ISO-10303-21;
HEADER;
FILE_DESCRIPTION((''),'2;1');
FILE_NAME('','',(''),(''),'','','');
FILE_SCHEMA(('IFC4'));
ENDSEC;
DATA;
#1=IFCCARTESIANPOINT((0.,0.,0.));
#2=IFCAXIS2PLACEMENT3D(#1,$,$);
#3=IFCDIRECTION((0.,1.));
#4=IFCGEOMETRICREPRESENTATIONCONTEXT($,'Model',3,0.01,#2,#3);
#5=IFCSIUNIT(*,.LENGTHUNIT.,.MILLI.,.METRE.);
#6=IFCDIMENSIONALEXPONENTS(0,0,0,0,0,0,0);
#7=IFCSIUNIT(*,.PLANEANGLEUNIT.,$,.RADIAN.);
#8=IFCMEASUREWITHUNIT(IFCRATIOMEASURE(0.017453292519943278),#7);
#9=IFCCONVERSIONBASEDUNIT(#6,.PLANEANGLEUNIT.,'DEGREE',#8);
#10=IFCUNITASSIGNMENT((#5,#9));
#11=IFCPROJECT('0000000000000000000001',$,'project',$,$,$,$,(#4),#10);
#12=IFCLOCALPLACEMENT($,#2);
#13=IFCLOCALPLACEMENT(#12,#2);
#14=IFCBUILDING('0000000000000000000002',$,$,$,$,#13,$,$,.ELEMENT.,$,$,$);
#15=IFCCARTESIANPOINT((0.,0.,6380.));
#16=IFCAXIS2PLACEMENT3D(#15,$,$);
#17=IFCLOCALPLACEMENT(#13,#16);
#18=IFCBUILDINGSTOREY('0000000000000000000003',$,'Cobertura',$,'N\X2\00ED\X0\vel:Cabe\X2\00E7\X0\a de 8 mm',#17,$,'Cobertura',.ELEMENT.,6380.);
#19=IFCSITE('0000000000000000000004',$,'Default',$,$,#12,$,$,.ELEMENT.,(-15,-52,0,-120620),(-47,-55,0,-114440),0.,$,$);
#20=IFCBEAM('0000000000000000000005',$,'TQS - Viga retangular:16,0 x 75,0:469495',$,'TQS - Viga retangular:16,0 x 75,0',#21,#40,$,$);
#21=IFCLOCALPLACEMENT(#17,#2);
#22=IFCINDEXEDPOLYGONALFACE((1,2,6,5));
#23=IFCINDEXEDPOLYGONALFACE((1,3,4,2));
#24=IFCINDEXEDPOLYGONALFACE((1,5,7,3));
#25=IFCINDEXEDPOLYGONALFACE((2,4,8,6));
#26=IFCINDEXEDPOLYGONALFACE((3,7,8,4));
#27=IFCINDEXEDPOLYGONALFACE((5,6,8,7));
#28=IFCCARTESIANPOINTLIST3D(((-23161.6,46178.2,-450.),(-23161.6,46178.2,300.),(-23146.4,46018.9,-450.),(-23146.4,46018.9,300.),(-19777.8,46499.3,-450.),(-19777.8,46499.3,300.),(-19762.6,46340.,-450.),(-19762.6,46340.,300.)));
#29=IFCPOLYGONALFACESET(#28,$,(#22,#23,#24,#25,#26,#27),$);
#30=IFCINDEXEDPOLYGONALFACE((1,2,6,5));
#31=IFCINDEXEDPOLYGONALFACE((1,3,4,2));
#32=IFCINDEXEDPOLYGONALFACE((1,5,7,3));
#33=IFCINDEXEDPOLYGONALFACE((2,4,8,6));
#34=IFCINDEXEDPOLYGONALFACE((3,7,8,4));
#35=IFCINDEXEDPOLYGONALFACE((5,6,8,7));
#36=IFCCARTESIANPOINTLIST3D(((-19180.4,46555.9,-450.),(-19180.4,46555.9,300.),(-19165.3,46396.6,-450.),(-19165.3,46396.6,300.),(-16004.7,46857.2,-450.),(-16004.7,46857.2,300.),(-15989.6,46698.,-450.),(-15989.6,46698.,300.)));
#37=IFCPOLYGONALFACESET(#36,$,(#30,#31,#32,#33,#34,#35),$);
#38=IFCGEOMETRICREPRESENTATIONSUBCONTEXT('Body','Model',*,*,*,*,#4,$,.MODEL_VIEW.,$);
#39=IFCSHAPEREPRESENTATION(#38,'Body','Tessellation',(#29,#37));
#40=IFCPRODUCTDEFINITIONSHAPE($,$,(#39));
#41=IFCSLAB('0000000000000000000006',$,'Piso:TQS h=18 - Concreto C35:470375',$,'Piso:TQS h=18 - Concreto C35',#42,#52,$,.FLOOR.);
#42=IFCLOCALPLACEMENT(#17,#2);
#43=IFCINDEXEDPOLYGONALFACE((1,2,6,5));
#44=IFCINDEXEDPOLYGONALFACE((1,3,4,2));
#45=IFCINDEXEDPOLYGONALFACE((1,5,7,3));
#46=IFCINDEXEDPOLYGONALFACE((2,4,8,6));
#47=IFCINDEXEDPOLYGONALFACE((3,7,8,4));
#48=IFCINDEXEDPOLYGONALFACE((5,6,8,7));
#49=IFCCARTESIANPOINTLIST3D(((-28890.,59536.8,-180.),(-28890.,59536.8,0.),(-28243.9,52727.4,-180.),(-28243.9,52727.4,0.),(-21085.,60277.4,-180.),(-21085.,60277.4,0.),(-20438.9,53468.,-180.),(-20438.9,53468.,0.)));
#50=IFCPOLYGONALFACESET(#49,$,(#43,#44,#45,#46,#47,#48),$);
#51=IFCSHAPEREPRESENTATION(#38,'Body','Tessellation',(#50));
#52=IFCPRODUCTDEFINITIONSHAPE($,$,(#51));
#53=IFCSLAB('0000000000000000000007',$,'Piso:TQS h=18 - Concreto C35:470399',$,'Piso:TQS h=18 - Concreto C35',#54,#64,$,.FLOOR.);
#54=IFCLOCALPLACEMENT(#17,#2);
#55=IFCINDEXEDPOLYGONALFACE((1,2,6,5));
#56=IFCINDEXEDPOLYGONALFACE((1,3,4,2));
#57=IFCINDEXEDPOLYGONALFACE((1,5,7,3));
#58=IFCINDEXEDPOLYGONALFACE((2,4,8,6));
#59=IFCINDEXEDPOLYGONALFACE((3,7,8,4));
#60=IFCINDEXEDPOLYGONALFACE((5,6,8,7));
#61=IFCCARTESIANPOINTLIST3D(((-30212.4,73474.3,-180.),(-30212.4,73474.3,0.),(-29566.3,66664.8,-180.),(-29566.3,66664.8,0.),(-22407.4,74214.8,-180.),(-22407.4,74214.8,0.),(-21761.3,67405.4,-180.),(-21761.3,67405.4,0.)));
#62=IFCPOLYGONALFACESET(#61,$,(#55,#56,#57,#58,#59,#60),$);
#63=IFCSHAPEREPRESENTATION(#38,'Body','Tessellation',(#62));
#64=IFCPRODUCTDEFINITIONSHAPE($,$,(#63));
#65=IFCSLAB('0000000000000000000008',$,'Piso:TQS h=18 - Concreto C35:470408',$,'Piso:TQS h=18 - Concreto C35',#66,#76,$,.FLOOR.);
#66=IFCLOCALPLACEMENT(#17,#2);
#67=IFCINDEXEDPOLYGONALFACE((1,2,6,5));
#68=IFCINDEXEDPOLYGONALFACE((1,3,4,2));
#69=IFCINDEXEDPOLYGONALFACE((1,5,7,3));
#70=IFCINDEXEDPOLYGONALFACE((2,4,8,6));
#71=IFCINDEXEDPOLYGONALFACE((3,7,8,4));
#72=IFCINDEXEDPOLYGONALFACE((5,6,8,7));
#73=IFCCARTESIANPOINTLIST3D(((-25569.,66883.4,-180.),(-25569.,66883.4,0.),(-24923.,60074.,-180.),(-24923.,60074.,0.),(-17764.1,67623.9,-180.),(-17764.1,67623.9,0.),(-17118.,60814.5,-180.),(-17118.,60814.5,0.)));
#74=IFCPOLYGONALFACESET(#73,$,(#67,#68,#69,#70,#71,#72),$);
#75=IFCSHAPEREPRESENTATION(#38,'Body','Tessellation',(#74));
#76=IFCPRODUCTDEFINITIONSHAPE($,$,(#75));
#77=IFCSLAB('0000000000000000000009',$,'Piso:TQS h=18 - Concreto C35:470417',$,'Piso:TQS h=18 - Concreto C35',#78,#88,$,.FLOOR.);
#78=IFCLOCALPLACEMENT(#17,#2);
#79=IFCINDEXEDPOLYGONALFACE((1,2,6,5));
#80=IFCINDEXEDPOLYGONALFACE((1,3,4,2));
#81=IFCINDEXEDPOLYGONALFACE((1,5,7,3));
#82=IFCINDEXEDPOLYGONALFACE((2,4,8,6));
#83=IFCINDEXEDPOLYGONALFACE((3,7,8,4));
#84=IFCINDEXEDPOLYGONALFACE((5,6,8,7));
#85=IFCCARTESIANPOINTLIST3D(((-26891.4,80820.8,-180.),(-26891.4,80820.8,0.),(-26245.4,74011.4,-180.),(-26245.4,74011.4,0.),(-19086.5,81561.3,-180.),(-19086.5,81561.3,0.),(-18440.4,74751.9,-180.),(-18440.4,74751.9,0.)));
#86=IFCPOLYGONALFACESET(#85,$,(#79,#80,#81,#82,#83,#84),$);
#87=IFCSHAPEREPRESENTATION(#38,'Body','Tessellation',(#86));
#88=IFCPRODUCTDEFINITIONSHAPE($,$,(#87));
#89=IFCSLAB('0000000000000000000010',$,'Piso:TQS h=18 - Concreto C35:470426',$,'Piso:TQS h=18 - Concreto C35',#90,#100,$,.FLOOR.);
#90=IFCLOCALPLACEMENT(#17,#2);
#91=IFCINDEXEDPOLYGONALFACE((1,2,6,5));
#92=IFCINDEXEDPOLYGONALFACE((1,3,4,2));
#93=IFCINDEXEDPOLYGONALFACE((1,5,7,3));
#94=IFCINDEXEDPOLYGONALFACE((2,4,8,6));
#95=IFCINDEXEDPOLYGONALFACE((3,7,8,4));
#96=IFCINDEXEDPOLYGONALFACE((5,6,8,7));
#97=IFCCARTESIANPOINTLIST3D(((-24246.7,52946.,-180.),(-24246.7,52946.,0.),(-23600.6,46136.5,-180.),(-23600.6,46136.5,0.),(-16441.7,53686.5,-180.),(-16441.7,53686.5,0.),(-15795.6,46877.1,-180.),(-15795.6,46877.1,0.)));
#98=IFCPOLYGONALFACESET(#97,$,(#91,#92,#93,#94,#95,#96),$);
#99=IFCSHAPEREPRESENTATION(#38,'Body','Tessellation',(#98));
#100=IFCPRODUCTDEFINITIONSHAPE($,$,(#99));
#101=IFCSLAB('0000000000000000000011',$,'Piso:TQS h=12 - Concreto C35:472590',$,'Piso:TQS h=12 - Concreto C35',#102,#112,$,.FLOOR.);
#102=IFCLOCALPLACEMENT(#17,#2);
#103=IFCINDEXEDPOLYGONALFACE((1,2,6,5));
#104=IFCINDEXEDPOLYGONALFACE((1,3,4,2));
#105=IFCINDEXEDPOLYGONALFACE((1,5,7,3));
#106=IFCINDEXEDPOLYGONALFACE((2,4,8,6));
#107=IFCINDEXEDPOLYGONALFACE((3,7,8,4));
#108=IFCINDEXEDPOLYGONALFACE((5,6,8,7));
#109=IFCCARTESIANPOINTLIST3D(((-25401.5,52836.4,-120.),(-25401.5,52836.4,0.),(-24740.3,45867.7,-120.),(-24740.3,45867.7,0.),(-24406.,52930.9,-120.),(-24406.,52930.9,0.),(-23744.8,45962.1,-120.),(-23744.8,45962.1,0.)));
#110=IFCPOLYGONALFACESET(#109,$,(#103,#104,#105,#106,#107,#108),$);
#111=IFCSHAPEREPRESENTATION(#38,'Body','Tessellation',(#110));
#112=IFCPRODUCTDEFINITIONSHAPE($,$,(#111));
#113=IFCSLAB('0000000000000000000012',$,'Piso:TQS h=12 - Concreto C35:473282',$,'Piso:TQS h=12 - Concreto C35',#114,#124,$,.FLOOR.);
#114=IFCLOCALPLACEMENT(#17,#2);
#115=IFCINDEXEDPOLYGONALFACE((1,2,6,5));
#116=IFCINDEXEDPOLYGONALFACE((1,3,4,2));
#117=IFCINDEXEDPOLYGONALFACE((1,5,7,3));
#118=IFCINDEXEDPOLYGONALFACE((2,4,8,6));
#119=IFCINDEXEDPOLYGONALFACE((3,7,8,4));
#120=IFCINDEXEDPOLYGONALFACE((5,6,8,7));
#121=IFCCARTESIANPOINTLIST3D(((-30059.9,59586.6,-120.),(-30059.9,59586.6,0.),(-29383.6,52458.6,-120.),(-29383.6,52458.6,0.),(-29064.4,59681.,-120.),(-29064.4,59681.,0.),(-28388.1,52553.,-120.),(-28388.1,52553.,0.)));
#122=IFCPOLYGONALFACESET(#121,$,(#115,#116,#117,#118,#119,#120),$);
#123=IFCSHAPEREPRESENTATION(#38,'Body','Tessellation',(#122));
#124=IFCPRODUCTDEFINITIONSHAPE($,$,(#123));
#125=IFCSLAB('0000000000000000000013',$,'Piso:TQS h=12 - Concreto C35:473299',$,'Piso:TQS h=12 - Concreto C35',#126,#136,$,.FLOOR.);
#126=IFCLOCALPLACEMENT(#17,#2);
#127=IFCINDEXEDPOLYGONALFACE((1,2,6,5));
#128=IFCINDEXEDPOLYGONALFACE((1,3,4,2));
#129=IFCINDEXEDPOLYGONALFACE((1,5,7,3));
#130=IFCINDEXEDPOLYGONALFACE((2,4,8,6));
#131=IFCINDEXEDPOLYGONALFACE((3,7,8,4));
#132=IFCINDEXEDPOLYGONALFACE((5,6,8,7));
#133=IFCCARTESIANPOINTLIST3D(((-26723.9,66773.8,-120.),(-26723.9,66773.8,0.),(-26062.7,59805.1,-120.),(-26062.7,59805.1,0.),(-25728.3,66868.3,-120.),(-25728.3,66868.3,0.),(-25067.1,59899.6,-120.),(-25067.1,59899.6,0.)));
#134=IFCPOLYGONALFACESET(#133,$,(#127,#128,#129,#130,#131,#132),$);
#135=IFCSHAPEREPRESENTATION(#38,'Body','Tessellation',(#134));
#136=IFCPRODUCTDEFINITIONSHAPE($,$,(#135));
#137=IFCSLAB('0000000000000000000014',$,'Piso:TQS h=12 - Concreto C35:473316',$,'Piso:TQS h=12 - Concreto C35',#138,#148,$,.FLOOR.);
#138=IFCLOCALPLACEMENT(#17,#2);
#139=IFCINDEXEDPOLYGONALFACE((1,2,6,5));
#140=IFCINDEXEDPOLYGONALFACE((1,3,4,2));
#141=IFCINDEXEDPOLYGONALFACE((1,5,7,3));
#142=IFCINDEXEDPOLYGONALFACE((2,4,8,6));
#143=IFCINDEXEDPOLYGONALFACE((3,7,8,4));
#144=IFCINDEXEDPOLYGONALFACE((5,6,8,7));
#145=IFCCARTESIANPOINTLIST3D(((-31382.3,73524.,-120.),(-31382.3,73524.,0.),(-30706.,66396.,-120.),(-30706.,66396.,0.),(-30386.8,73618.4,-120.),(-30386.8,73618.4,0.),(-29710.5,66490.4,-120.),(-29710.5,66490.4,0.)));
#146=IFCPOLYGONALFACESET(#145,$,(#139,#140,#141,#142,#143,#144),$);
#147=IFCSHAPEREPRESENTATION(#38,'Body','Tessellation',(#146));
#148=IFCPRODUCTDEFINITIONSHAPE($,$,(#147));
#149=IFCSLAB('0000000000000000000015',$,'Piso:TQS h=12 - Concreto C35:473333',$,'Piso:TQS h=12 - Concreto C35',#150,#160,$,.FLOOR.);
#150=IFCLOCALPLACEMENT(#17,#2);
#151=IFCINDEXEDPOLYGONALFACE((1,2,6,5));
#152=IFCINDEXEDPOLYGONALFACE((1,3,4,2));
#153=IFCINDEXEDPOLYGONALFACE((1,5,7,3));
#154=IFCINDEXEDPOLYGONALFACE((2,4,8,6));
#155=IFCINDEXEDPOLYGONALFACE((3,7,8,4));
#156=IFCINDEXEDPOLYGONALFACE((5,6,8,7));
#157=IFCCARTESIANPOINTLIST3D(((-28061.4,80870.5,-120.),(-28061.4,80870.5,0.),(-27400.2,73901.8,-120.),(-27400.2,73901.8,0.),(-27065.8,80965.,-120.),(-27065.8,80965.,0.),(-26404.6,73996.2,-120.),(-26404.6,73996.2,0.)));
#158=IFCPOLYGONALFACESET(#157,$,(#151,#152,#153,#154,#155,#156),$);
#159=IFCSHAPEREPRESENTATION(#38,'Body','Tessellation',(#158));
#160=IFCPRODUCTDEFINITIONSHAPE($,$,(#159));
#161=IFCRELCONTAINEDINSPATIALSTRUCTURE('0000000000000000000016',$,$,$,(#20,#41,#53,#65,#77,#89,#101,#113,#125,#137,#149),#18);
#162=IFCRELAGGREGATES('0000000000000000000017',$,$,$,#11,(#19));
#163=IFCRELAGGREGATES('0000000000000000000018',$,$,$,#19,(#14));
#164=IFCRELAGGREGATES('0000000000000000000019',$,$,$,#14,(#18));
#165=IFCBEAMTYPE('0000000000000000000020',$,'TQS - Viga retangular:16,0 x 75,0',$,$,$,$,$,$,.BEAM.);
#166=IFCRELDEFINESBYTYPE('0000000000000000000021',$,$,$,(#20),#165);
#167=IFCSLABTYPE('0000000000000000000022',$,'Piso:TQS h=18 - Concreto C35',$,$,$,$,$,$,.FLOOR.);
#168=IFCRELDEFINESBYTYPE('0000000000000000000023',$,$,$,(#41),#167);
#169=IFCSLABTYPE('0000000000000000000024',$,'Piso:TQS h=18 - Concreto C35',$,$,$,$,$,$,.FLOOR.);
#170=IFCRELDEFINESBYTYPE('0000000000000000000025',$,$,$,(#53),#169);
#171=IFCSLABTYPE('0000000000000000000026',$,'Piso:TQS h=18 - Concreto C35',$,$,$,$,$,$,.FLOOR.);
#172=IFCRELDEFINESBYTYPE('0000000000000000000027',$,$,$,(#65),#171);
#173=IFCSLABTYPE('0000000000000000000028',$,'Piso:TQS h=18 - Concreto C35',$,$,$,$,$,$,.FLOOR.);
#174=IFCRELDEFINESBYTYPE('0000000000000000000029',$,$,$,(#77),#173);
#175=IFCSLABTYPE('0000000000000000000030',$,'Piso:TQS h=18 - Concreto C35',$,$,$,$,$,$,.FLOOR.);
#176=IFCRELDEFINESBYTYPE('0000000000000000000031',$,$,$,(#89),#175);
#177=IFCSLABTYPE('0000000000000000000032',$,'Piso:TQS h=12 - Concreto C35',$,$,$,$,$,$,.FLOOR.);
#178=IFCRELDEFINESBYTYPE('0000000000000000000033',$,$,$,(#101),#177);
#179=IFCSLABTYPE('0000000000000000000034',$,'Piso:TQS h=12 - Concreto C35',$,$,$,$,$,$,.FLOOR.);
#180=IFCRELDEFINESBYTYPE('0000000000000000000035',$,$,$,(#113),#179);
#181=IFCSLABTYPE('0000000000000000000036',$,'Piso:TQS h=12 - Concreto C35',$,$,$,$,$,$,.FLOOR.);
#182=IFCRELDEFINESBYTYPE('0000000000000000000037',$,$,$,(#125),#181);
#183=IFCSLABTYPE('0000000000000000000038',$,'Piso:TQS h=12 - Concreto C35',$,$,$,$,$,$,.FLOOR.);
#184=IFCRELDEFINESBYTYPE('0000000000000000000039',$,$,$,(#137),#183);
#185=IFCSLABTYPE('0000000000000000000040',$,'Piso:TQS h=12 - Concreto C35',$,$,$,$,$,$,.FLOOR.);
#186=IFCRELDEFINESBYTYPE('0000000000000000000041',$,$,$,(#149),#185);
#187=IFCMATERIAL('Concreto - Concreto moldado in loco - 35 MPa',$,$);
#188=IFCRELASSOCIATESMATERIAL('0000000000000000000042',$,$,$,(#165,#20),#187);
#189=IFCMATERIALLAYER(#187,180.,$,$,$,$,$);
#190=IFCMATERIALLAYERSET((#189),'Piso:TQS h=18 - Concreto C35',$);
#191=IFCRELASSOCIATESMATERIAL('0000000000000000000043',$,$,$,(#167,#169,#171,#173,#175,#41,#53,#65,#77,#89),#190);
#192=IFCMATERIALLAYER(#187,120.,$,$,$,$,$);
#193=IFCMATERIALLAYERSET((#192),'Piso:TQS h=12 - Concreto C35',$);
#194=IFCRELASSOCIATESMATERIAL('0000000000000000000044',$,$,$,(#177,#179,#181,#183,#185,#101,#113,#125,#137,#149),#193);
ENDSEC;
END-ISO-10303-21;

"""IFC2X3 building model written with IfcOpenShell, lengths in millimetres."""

from ifc_helpers import new_model, entity, si_unit, converted_unit, direction, frame, frame_2d, origin, place, context, subcontext, project, spatial, rectangle, extrude, source, transform, mapped, material, layer, layer_set, layer_usage, type_object, type_shapes, element, save


model = new_model("IFC2X3")

# Units and contexts
model_context = context("Model", 3, precision=0.01, world=origin(), true_north=direction((0.0, 1.0)))
body_context = subcontext(model_context, "Body", "Model", "MODEL_VIEW")
ifc_project = project(units=[si_unit("LENGTHUNIT", "METRE", prefix="MILLI"), converted_unit("PLANEANGLEUNIT", "DEGREE", entity("IfcRatioMeasure", 0.017453292519943278), si_unit("PLANEANGLEUNIT", "RADIAN"), dimensions=[0, 0, 0, 0, 0, 0, 0])], contexts=[model_context])

# Site, building, storey
site_placement = place(None, origin())
site = spatial("IfcSite", under=ifc_project, at=site_placement, Name="Default", CompositionType="ELEMENT", RefLatitude=(-15, -52, 0, -120620), RefLongitude=(-47, -55, 0, -114440), RefElevation=0.0)
building_placement = place(site_placement, origin())
building = spatial("IfcBuilding", under=site, at=building_placement, CompositionType="ELEMENT")
storey_placement = place(building_placement, frame((0.0, 0.0, 6380.0)))
storey = spatial("IfcBuildingStorey", under=building, at=storey_placement, Name="Cobertura", ObjectType="Nível:Cabeça de 8 mm", LongName="Cobertura", CompositionType="ELEMENT", Elevation=6380.0)

# Beam
ifc_material = material(Name="Concreto - Concreto moldado in loco - 35 MPa")
beam_type_1 = type_object("IfcBeamType", Name="TQS - Viga retangular:16,0 x 75,0", PredefinedType="BEAM", material=ifc_material)
shared_shape_1 = source(origin(), body_context, "Body", "SweptSolid", [
    extrude(rectangle(XDim=750.0, YDim=160.0, at=frame_2d((0.0, 0.0), x_axis=(1.0, 0.0))), frame((-19770.2, 46419.6, 6305.0), z_axis=(-0.995529, -0.094456, 0.0), x_axis=(0.0, 0.0, -1.0)), (0.0, 0.0, 1.0), 3399.0),
    extrude(rectangle(XDim=750.0, YDim=160.0, at=frame_2d((0.0, 0.0), x_axis=(1.0, 0.0))), frame((-15997.1, 46777.6, 6305.0), z_axis=(-0.995529, -0.094456, 0.0), x_axis=(0.0, 0.0, -1.0)), (0.0, 0.0, 1.0), 3190.0),
])
type_shapes(beam_type_1, [shared_shape_1])
beam_1_placement = place(storey_placement, frame((0.0, 0.0, -6380.0)))
element("IfcBeam", 1, at=beam_1_placement, inside=storey, type_object=beam_type_1, material=ifc_material, Name="TQS - Viga retangular:16,0 x 75,0:469495", ObjectType="TQS - Viga retangular:16,0 x 75,0", context=body_context, shape_type="MappedRepresentation", body=[
    mapped(shared_shape_1, transform((0.0, 0.0, 0.0), scale=1.0)),
])

# Slabs
ifc_layer_1 = layer(ifc_material, 180.0)
ifc_layer_set_1 = layer_set([ifc_layer_1], Name="Piso:TQS h=18 - Concreto C35")
ifc_layer_usage_1 = layer_usage(ifc_layer_set_1, "AXIS3", "POSITIVE", 0.0)
slab_type_1 = type_object("IfcSlabType", Name="Piso:TQS h=18 - Concreto C35", PredefinedType="FLOOR", material=ifc_layer_set_1)
slab_1_placement = place(storey_placement, origin())
element("IfcSlab", 2, at=slab_1_placement, inside=storey, type_object=slab_type_1, material=ifc_layer_usage_1, Name="Piso:TQS h=18 - Concreto C35:470375", ObjectType="Piso:TQS h=18 - Concreto C35", PredefinedType="FLOOR", context=body_context, shape_type="SweptSolid", body=[
    extrude(rectangle(XDim=6840.0, YDim=7840.0, at=frame_2d((0.0, 0.0), x_axis=(1.0, 0.0))), frame((-24664.5, 56502.4, 0.0), z_axis=(0.0, 0.0, -1.0), x_axis=(0.094456, -0.995529, 0.0)), (0.0, 0.0, 1.0), 180.0),
])
ifc_layer_usage_2 = layer_usage(ifc_layer_set_1, "AXIS3", "POSITIVE", 0.0)
slab_type_2 = type_object("IfcSlabType", Name="Piso:TQS h=18 - Concreto C35", PredefinedType="FLOOR", material=ifc_layer_set_1)
slab_2_placement = place(storey_placement, origin())
element("IfcSlab", 3, at=slab_2_placement, inside=storey, type_object=slab_type_2, material=ifc_layer_usage_2, Name="Piso:TQS h=18 - Concreto C35:470399", ObjectType="Piso:TQS h=18 - Concreto C35", PredefinedType="FLOOR", context=body_context, shape_type="SweptSolid", body=[
    extrude(rectangle(XDim=6840.0, YDim=7840.0, at=frame_2d((0.0, 0.0), x_axis=(1.0, 0.0))), frame((-25986.8, 70439.8, 0.0), z_axis=(0.0, 0.0, -1.0), x_axis=(0.094456, -0.995529, 0.0)), (0.0, 0.0, 1.0), 180.0),
])
ifc_layer_usage_3 = layer_usage(ifc_layer_set_1, "AXIS3", "POSITIVE", 0.0)
slab_type_3 = type_object("IfcSlabType", Name="Piso:TQS h=18 - Concreto C35", PredefinedType="FLOOR", material=ifc_layer_set_1)
slab_3_placement = place(storey_placement, origin())
element("IfcSlab", 4, at=slab_3_placement, inside=storey, type_object=slab_type_3, material=ifc_layer_usage_3, Name="Piso:TQS h=18 - Concreto C35:470408", ObjectType="Piso:TQS h=18 - Concreto C35", PredefinedType="FLOOR", context=body_context, shape_type="SweptSolid", body=[
    extrude(rectangle(XDim=6840.0, YDim=7840.0, at=frame_2d((0.0, 0.0), x_axis=(1.0, 0.0))), frame((-21343.5, 63848.9, 0.0), z_axis=(0.0, 0.0, -1.0), x_axis=(0.094456, -0.995529, 0.0)), (0.0, 0.0, 1.0), 180.0),
])
ifc_layer_usage_4 = layer_usage(ifc_layer_set_1, "AXIS3", "POSITIVE", 0.0)
slab_type_4 = type_object("IfcSlabType", Name="Piso:TQS h=18 - Concreto C35", PredefinedType="FLOOR", material=ifc_layer_set_1)
slab_4_placement = place(storey_placement, origin())
element("IfcSlab", 5, at=slab_4_placement, inside=storey, type_object=slab_type_4, material=ifc_layer_usage_4, Name="Piso:TQS h=18 - Concreto C35:470417", ObjectType="Piso:TQS h=18 - Concreto C35", PredefinedType="FLOOR", context=body_context, shape_type="SweptSolid", body=[
    extrude(rectangle(XDim=7840.0, YDim=6840.0, at=frame_2d((0.0, 0.0), x_axis=(1.0, 0.0))), frame((-22665.9, 77786.3, 0.0), z_axis=(0.0, 0.0, -1.0), x_axis=(0.995529, 0.094456, 0.0)), (0.0, 0.0, 1.0), 180.0),
])
ifc_layer_usage_5 = layer_usage(ifc_layer_set_1, "AXIS3", "POSITIVE", 0.0)
slab_type_5 = type_object("IfcSlabType", Name="Piso:TQS h=18 - Concreto C35", PredefinedType="FLOOR", material=ifc_layer_set_1)
slab_5_placement = place(storey_placement, origin())
element("IfcSlab", 6, at=slab_5_placement, inside=storey, type_object=slab_type_5, material=ifc_layer_usage_5, Name="Piso:TQS h=18 - Concreto C35:470426", ObjectType="Piso:TQS h=18 - Concreto C35", PredefinedType="FLOOR", context=body_context, shape_type="SweptSolid", body=[
    extrude(rectangle(XDim=7840.0, YDim=6840.0, at=frame_2d((0.0, 0.0), x_axis=(1.0, 0.0))), frame((-20021.2, 49911.5, 0.0), z_axis=(0.0, 0.0, -1.0), x_axis=(0.995529, 0.094456, 0.0)), (0.0, 0.0, 1.0), 180.0),
])
ifc_layer_2 = layer(ifc_material, 120.0)
ifc_layer_set_2 = layer_set([ifc_layer_2], Name="Piso:TQS h=12 - Concreto C35")
ifc_layer_usage_6 = layer_usage(ifc_layer_set_2, "AXIS3", "POSITIVE", 0.0)
slab_type_6 = type_object("IfcSlabType", Name="Piso:TQS h=12 - Concreto C35", PredefinedType="FLOOR", material=ifc_layer_set_2)
slab_6_placement = place(storey_placement, origin())
element("IfcSlab", 7, at=slab_6_placement, inside=storey, type_object=slab_type_6, material=ifc_layer_usage_6, Name="Piso:TQS h=12 - Concreto C35:472590", ObjectType="Piso:TQS h=12 - Concreto C35", PredefinedType="FLOOR", context=body_context, shape_type="SweptSolid", body=[
    extrude(rectangle(XDim=7000.0, YDim=1000.0, at=frame_2d((0.0, 0.0), x_axis=(1.0, 0.0))), frame((-24573.1, 49399.3, 0.0), z_axis=(0.0, 0.0, -1.0), x_axis=(0.094456, -0.995529, 0.0)), (0.0, 0.0, 1.0), 120.0),
])
ifc_layer_usage_7 = layer_usage(ifc_layer_set_2, "AXIS3", "POSITIVE", 0.0)
slab_type_7 = type_object("IfcSlabType", Name="Piso:TQS h=12 - Concreto C35", PredefinedType="FLOOR", material=ifc_layer_set_2)
slab_7_placement = place(storey_placement, origin())
element("IfcSlab", 8, at=slab_7_placement, inside=storey, type_object=slab_type_7, material=ifc_layer_usage_7, Name="Piso:TQS h=12 - Concreto C35:473282", ObjectType="Piso:TQS h=12 - Concreto C35", PredefinedType="FLOOR", context=body_context, shape_type="SweptSolid", body=[
    extrude(rectangle(XDim=7160.0, YDim=1000.0, at=frame_2d((0.0, 0.0), x_axis=(1.0, 0.0))), frame((-29224.0, 56069.8, 0.0), z_axis=(0.0, 0.0, -1.0), x_axis=(0.094456, -0.995529, 0.0)), (0.0, 0.0, 1.0), 120.0),
])
ifc_layer_usage_8 = layer_usage(ifc_layer_set_2, "AXIS3", "POSITIVE", 0.0)
slab_type_8 = type_object("IfcSlabType", Name="Piso:TQS h=12 - Concreto C35", PredefinedType="FLOOR", material=ifc_layer_set_2)
slab_8_placement = place(storey_placement, origin())
element("IfcSlab", 9, at=slab_8_placement, inside=storey, type_object=slab_type_8, material=ifc_layer_usage_8, Name="Piso:TQS h=12 - Concreto C35:473299", ObjectType="Piso:TQS h=12 - Concreto C35", PredefinedType="FLOOR", context=body_context, shape_type="SweptSolid", body=[
    extrude(rectangle(XDim=7000.0, YDim=1000.0, at=frame_2d((0.0, 0.0), x_axis=(1.0, 0.0))), frame((-25895.5, 63336.7, 0.0), z_axis=(0.0, 0.0, -1.0), x_axis=(0.094456, -0.995529, 0.0)), (0.0, 0.0, 1.0), 120.0),
])
ifc_layer_usage_9 = layer_usage(ifc_layer_set_2, "AXIS3", "POSITIVE", 0.0)
slab_type_9 = type_object("IfcSlabType", Name="Piso:TQS h=12 - Concreto C35", PredefinedType="FLOOR", material=ifc_layer_set_2)
slab_9_placement = place(storey_placement, origin())
element("IfcSlab", 10, at=slab_9_placement, inside=storey, type_object=slab_type_9, material=ifc_layer_usage_9, Name="Piso:TQS h=12 - Concreto C35:473316", ObjectType="Piso:TQS h=12 - Concreto C35", PredefinedType="FLOOR", context=body_context, shape_type="SweptSolid", body=[
    extrude(rectangle(XDim=7160.0, YDim=1000.0, at=frame_2d((0.0, 0.0), x_axis=(1.0, 0.0))), frame((-30546.4, 70007.2, 0.0), z_axis=(0.0, 0.0, -1.0), x_axis=(0.094456, -0.995529, 0.0)), (0.0, 0.0, 1.0), 120.0),
])
ifc_layer_usage_10 = layer_usage(ifc_layer_set_2, "AXIS3", "POSITIVE", 0.0)
slab_type_10 = type_object("IfcSlabType", Name="Piso:TQS h=12 - Concreto C35", PredefinedType="FLOOR", material=ifc_layer_set_2)
slab_10_placement = place(storey_placement, origin())
element("IfcSlab", 11, at=slab_10_placement, inside=storey, type_object=slab_type_10, material=ifc_layer_usage_10, Name="Piso:TQS h=12 - Concreto C35:473333", ObjectType="Piso:TQS h=12 - Concreto C35", PredefinedType="FLOOR", context=body_context, shape_type="SweptSolid", body=[
    extrude(rectangle(XDim=7000.0, YDim=1000.0, at=frame_2d((0.0, 0.0), x_axis=(1.0, 0.0))), frame((-27233.0, 77433.4, 0.0), z_axis=(0.0, 0.0, -1.0), x_axis=(0.094456, -0.995529, 0.0)), (0.0, 0.0, 1.0), 120.0),
])

save(model, "model.ifc")
